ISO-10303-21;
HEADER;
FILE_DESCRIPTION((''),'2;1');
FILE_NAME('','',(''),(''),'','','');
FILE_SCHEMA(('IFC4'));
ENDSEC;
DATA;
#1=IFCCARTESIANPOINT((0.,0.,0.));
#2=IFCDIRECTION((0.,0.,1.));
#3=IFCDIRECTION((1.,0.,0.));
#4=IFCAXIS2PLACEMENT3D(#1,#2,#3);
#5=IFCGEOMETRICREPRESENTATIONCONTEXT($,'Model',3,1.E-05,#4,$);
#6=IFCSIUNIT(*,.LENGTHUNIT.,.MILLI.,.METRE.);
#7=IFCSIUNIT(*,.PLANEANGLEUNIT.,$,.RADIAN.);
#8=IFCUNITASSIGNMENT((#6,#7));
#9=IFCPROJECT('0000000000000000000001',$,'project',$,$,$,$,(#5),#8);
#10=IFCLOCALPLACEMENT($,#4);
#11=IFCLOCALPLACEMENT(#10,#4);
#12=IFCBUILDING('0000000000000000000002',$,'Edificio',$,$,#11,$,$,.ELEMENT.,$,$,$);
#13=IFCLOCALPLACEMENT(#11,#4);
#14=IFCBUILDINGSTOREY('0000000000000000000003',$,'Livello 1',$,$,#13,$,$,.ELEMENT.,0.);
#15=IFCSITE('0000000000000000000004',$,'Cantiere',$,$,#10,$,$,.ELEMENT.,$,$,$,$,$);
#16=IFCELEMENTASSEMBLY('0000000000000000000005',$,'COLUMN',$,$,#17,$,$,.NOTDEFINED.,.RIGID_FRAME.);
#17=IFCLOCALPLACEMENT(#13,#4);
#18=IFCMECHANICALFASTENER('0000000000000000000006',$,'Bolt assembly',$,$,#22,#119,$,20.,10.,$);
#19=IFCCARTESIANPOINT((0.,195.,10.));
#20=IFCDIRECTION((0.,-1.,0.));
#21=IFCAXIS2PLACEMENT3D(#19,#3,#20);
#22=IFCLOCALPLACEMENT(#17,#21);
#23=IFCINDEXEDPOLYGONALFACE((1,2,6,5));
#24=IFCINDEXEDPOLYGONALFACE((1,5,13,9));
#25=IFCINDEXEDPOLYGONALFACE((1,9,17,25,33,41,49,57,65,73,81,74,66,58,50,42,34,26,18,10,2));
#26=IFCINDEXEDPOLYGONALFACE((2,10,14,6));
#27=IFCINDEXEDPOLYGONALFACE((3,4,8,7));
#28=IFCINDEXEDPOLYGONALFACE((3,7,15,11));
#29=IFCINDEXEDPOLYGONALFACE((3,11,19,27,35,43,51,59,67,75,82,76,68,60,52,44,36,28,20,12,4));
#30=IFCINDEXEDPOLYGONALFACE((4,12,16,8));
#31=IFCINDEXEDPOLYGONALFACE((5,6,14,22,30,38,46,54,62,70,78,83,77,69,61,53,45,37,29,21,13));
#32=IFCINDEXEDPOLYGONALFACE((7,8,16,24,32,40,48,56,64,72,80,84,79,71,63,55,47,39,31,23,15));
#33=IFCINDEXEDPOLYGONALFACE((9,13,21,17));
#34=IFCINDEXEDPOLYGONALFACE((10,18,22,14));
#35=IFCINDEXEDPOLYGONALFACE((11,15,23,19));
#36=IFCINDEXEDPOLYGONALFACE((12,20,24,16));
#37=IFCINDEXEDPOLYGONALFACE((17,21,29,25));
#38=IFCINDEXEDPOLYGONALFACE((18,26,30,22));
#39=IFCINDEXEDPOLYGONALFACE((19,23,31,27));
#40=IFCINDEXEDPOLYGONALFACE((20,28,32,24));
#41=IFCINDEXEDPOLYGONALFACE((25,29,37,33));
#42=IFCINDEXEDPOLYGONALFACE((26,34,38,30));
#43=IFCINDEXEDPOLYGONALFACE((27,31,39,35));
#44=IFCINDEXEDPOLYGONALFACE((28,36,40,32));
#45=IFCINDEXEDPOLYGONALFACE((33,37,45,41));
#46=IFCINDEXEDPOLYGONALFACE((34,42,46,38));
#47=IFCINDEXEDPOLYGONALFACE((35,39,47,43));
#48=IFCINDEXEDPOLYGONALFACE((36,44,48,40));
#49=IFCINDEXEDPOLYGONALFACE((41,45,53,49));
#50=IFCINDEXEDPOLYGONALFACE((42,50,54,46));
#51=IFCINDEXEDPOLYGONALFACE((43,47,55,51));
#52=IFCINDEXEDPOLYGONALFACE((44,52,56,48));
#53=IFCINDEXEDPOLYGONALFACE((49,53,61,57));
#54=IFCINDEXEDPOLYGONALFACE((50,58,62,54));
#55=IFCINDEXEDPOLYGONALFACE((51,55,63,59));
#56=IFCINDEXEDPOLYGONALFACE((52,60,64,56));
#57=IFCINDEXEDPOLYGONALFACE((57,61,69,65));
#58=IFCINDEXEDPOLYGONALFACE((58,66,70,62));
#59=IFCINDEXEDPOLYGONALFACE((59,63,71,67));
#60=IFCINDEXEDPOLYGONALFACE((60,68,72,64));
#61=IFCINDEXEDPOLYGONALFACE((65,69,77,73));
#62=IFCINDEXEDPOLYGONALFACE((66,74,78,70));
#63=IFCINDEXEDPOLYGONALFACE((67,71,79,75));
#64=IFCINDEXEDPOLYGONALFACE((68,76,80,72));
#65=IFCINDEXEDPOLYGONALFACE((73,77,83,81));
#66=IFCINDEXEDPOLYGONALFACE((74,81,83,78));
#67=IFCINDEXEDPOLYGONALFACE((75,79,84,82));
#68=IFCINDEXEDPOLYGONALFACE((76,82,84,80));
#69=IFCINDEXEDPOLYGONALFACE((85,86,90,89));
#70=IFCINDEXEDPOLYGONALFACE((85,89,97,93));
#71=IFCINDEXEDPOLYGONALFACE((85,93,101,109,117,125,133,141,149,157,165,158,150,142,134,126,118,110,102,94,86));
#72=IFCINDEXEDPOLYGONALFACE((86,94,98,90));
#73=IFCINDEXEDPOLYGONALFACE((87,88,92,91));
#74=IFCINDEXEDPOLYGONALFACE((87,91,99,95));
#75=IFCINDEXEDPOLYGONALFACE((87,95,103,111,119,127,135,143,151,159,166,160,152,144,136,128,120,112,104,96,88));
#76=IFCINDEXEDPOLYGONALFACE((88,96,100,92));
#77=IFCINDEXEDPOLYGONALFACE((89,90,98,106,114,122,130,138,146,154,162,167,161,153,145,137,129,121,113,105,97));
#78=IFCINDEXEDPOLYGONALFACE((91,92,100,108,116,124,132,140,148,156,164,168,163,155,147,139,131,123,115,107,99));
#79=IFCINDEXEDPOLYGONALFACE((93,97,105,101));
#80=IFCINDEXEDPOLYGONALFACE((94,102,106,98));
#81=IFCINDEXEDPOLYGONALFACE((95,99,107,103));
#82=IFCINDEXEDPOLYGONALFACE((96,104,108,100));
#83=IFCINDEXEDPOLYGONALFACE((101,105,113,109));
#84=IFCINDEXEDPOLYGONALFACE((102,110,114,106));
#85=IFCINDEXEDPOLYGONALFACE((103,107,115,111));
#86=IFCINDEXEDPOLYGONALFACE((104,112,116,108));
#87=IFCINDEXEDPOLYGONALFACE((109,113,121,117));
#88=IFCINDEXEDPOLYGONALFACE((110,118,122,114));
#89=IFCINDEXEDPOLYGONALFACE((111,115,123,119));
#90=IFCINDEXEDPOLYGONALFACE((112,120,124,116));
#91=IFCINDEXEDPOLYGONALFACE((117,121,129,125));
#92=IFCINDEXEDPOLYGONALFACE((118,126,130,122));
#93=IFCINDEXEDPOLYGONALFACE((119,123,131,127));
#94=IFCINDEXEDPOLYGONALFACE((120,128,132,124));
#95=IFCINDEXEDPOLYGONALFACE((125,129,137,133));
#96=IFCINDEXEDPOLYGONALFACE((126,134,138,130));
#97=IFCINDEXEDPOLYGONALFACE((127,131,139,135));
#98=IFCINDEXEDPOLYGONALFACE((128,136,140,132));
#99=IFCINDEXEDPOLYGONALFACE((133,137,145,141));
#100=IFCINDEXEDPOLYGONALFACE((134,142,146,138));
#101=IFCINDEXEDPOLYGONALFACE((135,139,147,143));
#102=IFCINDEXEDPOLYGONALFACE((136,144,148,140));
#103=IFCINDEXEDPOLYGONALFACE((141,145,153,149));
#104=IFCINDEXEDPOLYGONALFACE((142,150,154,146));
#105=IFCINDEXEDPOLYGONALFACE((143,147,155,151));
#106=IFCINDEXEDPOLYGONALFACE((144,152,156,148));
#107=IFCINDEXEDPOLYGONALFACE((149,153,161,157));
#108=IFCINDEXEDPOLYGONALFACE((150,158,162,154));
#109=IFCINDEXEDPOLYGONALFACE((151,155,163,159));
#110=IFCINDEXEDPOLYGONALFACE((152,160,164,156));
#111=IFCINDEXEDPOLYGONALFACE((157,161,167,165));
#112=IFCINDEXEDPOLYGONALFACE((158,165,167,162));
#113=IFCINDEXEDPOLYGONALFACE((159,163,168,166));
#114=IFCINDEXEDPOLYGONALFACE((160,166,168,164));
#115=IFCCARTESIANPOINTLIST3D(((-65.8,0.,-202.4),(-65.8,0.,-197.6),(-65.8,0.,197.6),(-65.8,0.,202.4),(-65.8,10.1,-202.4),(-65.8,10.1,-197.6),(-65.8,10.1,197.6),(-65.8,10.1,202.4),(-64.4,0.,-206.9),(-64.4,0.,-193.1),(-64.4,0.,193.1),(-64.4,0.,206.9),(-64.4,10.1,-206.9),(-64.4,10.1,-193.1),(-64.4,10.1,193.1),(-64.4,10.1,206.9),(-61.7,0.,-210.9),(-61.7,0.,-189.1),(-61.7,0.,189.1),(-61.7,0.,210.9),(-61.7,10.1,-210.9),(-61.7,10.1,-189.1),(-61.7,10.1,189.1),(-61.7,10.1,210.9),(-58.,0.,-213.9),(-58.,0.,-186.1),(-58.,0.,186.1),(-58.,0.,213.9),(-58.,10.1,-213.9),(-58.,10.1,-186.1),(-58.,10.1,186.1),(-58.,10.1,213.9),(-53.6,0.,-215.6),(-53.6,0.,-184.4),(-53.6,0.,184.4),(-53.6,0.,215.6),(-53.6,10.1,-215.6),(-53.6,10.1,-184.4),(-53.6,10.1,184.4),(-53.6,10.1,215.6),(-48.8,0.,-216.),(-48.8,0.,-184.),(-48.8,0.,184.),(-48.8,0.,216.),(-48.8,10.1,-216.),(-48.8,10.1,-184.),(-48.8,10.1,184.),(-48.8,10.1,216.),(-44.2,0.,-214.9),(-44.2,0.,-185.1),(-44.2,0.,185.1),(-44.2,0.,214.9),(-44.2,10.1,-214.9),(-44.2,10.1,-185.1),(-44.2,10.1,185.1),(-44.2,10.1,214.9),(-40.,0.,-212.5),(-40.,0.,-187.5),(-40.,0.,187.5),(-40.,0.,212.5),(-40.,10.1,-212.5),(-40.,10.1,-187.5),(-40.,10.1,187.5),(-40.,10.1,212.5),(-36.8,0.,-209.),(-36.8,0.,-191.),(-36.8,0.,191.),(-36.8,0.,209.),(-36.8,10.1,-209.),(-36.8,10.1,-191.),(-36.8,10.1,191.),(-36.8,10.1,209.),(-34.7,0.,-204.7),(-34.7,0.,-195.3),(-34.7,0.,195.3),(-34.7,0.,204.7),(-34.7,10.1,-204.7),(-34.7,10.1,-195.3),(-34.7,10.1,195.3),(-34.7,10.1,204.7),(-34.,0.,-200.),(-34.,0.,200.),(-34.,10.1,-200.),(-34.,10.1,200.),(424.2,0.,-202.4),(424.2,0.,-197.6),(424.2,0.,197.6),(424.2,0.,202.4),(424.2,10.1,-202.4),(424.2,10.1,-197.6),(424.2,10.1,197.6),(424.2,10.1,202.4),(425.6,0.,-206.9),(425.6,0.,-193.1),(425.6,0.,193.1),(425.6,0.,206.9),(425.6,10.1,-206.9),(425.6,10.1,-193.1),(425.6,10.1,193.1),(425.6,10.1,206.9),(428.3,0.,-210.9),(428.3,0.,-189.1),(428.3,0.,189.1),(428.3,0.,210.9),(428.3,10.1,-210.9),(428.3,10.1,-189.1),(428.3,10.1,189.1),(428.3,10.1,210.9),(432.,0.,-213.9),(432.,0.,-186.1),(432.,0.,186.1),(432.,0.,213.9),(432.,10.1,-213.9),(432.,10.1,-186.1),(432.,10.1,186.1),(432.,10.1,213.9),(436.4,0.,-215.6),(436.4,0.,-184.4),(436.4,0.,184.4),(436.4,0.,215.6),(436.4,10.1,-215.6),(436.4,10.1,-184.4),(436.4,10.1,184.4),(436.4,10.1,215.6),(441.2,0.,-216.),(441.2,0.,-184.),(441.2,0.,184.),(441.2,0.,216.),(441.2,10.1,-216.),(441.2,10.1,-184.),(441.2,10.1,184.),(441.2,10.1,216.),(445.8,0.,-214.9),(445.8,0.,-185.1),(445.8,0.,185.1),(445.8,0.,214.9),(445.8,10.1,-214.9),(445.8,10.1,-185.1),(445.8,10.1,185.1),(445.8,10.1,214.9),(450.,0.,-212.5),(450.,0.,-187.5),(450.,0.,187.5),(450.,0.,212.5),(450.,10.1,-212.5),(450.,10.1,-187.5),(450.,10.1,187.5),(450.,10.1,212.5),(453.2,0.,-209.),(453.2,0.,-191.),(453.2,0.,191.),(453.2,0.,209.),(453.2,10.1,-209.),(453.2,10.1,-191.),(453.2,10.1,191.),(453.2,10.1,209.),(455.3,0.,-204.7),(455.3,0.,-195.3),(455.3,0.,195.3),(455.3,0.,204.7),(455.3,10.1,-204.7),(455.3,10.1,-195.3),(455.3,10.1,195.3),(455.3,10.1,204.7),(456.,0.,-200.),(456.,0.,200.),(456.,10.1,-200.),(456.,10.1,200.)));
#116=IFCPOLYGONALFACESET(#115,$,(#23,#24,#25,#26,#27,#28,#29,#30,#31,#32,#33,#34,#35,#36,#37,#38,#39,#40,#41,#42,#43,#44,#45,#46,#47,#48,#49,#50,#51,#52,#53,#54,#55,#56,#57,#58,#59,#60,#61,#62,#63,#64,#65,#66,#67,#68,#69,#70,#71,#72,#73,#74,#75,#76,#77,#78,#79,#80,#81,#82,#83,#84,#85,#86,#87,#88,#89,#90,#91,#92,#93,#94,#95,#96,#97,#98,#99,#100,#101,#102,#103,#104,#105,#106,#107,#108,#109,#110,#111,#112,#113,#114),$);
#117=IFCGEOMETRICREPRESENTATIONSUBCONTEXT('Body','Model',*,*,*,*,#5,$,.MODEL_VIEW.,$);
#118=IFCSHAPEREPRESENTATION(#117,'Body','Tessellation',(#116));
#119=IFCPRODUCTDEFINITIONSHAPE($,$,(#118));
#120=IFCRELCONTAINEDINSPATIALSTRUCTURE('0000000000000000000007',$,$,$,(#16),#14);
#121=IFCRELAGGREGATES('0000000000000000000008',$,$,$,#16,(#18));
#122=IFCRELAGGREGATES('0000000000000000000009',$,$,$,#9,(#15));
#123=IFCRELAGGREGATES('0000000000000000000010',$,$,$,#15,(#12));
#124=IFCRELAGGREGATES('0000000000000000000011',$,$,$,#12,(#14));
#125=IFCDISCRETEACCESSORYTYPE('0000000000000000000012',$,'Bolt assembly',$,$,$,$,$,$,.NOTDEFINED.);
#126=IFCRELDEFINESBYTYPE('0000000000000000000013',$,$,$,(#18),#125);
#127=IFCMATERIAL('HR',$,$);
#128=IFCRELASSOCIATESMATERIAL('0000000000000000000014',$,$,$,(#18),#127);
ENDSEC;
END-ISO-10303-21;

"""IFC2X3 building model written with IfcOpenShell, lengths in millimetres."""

from ifc_helpers import new_model, si_unit, frame, origin_with_axes, origin_2d_with_axis, place, context, subcontext, project, spatial, circle, extrude, source, transform, mapped, material, type_object, element, aggregate, save


model = new_model("IFC2X3")

# Units and contexts
model_context = context("Model", 3, precision=1e-05, world=origin_with_axes())
body_context = subcontext(model_context, "Body", "Model", "MODEL_VIEW")
ifc_project = project(units=[si_unit("LENGTHUNIT", "METRE", prefix="MILLI"), si_unit("PLANEANGLEUNIT", "RADIAN")], contexts=[model_context])

# Site, building, storey
site_placement = place(None, origin_with_axes())
site = spatial("IfcSite", under=ifc_project, at=site_placement, Name="Cantiere", CompositionType="ELEMENT")
building_placement = place(site_placement, origin_with_axes())
building = spatial("IfcBuilding", under=site, at=building_placement, Name="Edificio", CompositionType="ELEMENT")
storey_placement = place(building_placement, origin_with_axes())
storey = spatial("IfcBuildingStorey", under=building, at=storey_placement, Name="Livello 1", CompositionType="ELEMENT", Elevation=0.0)

# Element assembly
assembly_1_placement = place(storey_placement, origin_with_axes())
assembly_1 = element("IfcElementAssembly", 1, at=assembly_1_placement, inside=storey, Name="COLUMN", AssemblyPlace="NOTDEFINED", PredefinedType="RIGID_FRAME")

# Mechanical fastener
ifc_material_1 = material(Name="HR")
discrete_accessory_type_1 = type_object("IfcDiscreteAccessoryType", Name="Bolt assembly")
shared_shape_1 = source(origin_with_axes(), body_context, "Body", "SweptSolid", [
    extrude(circle(Radius=16.0, at=origin_2d_with_axis()), frame((0.0, 0.0, 0.0), z_axis=(0.0, 1.0, 0.0), x_axis=(1.0, 0.0, 0.0)), (0.0, 0.0, 1.0), 10.1),
])
mechanical_fastener_1_placement = place(assembly_1_placement, frame((0.0, 195.0, 10.0), z_axis=(1.0, 0.0, 0.0), x_axis=(0.0, -1.0, 0.0)))
mechanical_fastener_1 = element("IfcMechanicalFastener", 2, at=mechanical_fastener_1_placement, type_object=discrete_accessory_type_1, material=ifc_material_1, Name="Bolt assembly", NominalDiameter=20.0, NominalLength=10.0, context=body_context, shape_type="MappedRepresentation", body=[
    mapped(shared_shape_1, transform((-50.0, 0.0, -200.0))),
    mapped(shared_shape_1, transform((-50.0, 0.0, 200.0))),
    mapped(shared_shape_1, transform((440.0, 0.0, -200.0))),
    mapped(shared_shape_1, transform((440.0, 0.0, 200.0))),
])

aggregate(assembly_1, [mechanical_fastener_1])

save(model, "model.ifc")
